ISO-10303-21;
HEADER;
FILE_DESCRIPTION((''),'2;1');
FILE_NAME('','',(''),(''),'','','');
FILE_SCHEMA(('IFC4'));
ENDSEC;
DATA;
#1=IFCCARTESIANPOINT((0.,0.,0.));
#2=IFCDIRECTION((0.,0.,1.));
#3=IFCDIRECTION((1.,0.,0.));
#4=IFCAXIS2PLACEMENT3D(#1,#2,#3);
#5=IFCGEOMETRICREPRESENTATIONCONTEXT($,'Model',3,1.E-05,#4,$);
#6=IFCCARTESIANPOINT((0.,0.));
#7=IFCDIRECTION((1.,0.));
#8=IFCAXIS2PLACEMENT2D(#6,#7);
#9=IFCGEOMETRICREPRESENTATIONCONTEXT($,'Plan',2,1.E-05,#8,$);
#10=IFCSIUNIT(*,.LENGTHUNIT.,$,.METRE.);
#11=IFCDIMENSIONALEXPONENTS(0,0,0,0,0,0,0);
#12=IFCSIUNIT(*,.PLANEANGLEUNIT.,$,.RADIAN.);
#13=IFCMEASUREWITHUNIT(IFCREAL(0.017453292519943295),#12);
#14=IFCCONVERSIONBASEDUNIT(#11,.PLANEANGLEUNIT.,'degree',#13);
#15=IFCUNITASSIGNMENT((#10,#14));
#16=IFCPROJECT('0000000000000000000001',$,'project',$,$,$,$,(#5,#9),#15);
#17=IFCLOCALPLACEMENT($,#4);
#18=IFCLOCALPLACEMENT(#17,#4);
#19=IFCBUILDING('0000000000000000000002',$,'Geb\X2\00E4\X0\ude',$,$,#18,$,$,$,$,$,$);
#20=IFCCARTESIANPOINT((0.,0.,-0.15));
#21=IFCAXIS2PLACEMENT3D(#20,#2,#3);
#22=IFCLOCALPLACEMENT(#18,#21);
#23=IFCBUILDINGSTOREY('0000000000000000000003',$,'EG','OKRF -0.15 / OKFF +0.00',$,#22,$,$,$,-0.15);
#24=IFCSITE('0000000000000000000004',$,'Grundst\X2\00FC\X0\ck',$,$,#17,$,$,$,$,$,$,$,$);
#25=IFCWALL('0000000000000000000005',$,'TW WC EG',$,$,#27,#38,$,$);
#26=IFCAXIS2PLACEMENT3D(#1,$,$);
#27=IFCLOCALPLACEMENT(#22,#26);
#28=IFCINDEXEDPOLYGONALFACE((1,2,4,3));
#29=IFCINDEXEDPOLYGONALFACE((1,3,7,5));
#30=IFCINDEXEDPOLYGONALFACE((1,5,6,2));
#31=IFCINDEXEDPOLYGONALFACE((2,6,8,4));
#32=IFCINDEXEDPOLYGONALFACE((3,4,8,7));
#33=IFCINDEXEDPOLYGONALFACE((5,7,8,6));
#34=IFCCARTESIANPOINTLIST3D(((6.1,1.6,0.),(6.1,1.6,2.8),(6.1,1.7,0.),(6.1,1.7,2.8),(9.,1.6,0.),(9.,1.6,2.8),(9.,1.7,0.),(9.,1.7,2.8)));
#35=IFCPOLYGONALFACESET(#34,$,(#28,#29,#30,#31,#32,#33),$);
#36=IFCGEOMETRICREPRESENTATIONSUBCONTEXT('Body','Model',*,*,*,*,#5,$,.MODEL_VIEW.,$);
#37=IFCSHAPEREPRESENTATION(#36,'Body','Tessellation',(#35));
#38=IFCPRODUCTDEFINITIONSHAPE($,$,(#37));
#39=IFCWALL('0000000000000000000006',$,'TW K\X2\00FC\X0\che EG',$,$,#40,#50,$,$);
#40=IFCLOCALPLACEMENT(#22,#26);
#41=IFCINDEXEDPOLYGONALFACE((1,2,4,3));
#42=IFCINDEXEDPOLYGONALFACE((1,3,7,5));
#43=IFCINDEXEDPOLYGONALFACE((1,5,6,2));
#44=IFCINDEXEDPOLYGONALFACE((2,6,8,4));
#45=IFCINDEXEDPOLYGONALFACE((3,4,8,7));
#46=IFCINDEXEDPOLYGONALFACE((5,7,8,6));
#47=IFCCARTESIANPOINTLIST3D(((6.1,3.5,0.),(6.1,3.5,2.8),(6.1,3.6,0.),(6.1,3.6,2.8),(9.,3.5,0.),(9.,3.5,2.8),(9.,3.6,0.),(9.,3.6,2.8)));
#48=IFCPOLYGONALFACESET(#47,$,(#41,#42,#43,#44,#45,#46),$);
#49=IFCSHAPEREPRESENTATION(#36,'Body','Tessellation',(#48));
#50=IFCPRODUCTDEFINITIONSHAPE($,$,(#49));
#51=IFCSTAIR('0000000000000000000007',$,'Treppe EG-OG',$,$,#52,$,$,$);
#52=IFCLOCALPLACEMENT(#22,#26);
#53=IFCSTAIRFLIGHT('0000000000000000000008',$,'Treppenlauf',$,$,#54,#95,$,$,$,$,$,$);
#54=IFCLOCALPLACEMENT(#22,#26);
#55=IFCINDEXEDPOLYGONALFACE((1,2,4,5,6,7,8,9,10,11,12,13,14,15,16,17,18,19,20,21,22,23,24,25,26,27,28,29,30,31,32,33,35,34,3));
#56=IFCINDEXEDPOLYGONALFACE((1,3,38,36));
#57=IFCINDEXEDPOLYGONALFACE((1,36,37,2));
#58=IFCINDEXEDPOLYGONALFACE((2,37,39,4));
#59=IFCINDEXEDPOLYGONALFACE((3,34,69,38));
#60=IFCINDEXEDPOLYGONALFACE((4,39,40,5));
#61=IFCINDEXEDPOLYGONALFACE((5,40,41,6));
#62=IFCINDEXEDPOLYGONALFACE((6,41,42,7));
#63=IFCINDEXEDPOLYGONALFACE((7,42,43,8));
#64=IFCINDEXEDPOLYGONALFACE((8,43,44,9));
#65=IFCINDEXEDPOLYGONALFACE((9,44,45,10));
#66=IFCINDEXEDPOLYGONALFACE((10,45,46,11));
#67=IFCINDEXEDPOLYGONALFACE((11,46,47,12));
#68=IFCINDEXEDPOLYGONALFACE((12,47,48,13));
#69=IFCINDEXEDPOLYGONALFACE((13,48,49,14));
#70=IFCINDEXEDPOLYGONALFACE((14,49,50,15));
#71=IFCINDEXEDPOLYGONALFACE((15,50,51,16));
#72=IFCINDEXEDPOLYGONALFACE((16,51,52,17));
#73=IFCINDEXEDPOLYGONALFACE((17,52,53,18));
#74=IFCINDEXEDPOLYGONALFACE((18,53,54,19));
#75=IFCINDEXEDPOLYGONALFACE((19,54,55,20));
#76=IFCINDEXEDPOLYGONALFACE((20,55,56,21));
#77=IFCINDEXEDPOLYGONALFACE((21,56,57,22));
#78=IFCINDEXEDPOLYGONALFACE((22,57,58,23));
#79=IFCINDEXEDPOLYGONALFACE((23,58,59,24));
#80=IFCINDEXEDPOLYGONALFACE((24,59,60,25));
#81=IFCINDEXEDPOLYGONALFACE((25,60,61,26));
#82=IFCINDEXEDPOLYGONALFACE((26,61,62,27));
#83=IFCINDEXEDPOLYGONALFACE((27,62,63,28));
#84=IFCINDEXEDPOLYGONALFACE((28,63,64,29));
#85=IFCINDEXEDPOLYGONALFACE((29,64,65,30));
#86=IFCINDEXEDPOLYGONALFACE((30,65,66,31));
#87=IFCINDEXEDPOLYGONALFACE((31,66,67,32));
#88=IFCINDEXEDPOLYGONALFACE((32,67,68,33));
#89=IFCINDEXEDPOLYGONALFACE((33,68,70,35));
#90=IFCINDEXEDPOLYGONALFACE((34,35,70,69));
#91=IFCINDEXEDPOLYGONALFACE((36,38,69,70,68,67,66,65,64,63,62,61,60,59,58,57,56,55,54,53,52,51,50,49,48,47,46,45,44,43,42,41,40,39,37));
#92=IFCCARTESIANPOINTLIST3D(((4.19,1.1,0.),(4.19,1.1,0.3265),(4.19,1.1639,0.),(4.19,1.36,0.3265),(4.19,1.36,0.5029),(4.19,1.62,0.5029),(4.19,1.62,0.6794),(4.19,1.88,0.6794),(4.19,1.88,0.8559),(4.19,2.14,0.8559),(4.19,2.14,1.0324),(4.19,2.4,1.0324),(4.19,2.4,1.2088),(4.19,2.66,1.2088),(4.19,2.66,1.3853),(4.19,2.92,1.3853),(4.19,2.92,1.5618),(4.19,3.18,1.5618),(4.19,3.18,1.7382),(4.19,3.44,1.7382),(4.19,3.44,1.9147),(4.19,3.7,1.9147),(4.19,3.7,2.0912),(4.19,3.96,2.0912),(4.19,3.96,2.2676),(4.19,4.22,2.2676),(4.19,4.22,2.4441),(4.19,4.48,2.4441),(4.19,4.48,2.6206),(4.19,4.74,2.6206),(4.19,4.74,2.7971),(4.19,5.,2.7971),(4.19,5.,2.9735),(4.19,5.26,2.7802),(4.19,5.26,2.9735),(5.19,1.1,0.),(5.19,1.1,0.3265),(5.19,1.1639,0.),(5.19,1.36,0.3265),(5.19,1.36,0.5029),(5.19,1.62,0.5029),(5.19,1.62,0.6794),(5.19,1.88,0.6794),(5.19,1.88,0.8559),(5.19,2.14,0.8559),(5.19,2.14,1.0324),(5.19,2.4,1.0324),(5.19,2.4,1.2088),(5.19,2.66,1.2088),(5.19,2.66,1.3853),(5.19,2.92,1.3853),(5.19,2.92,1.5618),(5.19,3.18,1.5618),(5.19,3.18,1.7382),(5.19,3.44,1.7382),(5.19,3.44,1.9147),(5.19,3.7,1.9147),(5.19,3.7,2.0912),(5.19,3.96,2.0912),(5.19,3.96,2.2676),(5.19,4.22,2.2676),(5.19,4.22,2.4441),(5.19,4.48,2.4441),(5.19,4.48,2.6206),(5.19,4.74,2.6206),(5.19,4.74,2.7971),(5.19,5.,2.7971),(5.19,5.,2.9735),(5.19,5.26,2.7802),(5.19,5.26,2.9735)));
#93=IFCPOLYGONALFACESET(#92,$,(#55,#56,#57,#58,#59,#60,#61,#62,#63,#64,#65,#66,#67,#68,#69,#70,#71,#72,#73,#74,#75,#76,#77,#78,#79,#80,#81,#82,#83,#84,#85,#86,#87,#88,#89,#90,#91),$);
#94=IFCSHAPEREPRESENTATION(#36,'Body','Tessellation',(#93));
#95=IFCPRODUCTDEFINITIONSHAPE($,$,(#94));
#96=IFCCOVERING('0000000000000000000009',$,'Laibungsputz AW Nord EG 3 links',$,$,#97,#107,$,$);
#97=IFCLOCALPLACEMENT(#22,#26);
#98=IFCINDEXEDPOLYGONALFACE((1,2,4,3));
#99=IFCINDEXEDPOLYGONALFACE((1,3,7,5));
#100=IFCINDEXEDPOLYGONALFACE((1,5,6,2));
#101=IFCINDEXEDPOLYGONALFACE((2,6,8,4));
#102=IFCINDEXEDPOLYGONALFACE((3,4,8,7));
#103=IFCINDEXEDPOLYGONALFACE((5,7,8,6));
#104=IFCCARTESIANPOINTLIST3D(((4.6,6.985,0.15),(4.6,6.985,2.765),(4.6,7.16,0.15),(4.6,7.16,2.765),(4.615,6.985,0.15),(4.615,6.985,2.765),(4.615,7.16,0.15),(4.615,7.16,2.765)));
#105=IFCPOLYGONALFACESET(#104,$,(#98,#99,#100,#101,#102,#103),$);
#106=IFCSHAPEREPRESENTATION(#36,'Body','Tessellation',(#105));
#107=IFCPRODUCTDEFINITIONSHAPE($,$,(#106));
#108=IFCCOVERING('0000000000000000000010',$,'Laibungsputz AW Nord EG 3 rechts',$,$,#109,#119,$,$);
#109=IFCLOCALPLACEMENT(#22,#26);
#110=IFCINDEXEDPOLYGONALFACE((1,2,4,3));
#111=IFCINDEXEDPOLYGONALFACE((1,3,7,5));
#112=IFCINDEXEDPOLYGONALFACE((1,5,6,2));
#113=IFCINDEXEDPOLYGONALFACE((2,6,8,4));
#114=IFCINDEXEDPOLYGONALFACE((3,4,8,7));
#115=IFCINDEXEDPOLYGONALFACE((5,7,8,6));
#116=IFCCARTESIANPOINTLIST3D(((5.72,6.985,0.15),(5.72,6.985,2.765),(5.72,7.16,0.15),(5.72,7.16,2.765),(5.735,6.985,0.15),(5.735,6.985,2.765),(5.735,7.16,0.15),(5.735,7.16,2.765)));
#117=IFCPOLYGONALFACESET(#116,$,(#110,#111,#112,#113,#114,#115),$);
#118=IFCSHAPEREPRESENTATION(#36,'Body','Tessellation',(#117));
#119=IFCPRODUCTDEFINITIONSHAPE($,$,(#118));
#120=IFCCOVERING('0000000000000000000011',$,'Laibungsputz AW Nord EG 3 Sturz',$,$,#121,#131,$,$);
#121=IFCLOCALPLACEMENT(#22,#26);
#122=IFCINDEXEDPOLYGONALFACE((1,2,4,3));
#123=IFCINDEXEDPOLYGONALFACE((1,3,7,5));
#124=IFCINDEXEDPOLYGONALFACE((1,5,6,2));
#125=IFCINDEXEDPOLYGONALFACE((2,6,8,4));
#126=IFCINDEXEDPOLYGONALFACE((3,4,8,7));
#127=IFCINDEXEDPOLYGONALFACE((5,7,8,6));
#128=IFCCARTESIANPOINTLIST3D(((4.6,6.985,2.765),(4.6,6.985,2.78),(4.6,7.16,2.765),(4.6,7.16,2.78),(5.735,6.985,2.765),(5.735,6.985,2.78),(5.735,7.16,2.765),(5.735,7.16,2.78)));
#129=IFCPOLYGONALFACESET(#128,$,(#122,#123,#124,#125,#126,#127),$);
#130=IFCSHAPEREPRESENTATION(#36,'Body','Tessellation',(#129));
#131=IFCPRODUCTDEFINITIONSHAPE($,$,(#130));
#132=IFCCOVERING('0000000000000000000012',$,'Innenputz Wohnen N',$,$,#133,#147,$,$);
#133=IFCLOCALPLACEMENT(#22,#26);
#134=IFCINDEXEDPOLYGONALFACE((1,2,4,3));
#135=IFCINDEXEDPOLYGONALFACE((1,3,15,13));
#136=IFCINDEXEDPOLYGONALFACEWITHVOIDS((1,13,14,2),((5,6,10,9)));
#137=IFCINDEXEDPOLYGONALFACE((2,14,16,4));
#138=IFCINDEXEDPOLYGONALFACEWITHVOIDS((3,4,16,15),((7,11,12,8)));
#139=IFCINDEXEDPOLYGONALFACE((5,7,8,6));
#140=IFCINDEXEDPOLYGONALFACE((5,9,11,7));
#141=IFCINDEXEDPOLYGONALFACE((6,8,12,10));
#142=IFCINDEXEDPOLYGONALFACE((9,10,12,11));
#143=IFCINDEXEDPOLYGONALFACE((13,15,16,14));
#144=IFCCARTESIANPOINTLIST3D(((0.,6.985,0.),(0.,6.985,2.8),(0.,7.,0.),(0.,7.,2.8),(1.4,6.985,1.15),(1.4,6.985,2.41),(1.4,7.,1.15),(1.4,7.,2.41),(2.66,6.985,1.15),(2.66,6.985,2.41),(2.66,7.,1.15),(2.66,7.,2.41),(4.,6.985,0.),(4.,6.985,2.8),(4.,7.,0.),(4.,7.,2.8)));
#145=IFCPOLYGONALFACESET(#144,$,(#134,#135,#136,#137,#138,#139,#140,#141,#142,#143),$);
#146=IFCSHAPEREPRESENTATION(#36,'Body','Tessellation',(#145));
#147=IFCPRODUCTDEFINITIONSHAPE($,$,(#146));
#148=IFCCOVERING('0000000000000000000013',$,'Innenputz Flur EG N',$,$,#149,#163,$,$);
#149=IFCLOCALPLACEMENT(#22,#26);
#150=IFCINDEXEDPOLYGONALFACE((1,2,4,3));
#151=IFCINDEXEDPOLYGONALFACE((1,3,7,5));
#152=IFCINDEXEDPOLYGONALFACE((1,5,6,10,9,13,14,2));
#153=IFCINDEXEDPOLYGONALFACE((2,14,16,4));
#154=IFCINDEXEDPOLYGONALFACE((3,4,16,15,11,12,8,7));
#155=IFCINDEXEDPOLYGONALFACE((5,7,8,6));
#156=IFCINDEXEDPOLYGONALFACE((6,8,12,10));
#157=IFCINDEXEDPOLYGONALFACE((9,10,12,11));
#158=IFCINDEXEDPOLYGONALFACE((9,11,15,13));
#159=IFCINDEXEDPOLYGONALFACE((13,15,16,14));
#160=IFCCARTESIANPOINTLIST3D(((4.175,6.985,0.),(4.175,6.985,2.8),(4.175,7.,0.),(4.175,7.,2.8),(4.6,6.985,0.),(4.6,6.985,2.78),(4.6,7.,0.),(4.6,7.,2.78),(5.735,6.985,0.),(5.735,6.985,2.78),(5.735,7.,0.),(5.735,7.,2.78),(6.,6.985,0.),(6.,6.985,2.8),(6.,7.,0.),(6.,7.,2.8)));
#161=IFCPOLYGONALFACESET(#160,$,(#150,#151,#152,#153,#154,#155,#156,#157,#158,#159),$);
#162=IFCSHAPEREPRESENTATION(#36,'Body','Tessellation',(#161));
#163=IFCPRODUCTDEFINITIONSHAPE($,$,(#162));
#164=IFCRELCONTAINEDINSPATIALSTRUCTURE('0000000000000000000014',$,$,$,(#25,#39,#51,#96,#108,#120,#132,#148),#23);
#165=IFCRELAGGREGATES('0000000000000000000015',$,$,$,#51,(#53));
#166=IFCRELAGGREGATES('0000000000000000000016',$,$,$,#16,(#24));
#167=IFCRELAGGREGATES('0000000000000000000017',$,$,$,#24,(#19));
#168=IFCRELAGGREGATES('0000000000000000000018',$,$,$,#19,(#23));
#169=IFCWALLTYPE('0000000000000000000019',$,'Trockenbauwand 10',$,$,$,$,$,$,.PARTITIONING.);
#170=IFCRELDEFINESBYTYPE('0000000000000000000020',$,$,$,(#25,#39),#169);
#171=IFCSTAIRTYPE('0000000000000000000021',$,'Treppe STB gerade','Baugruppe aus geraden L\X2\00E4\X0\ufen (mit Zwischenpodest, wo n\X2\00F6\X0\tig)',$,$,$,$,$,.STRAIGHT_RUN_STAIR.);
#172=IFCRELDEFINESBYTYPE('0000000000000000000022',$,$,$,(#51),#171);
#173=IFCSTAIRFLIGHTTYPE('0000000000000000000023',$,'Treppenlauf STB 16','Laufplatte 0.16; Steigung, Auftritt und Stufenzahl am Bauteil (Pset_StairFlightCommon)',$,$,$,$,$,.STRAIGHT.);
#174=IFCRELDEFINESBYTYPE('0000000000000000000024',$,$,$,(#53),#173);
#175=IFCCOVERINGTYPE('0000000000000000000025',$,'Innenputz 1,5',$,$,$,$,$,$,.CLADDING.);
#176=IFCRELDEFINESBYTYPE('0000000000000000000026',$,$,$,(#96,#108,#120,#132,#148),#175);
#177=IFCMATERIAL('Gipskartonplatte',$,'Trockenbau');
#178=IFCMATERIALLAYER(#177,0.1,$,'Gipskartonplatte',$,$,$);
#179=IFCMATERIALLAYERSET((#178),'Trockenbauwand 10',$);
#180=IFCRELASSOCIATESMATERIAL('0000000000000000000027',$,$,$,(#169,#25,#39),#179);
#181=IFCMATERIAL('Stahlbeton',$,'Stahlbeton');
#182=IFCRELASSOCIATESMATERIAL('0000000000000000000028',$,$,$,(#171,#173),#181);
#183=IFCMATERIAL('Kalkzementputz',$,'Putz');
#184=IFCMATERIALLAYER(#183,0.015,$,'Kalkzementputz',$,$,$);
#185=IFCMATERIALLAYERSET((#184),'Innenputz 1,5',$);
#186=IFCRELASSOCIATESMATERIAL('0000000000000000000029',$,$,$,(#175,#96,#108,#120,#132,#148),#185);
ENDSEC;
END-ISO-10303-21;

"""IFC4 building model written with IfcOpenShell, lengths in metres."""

from ifc_helpers import new_model, entity, si_unit, converted_unit, frame, origin, origin_with_axes, origin_2d_with_axis, place, context, subcontext, project, spatial, polyline, line, indexed_curve, outline, extrude, material, layer, layer_set, layer_usage, type_object, element, aggregate, save


model = new_model("IFC4")

# Units and contexts
model_context = context("Model", 3, precision=1e-05, world=origin_with_axes())
plan_context = context("Plan", 2, precision=1e-05, world=origin_2d_with_axis())
body_context_1 = subcontext(model_context, "Body", "Model", "MODEL_VIEW")
ifc_project = project(units=[si_unit("LENGTHUNIT", "METRE"), converted_unit("PLANEANGLEUNIT", "degree", entity("IfcReal", 0.017453292519943295), si_unit("PLANEANGLEUNIT", "RADIAN"), dimensions=[0, 0, 0, 0, 0, 0, 0])], contexts=[model_context, plan_context])

# Site, building, storey
site_placement = place(None, origin_with_axes())
site = spatial("IfcSite", under=ifc_project, at=site_placement, Name="Grundstück")
building_placement = place(site_placement, origin_with_axes())
building = spatial("IfcBuilding", under=site, at=building_placement, Name="Gebäude")
storey_placement = place(building_placement, frame((0.0, 0.0, -0.15), z_axis=(0.0, 0.0, 1.0), x_axis=(1.0, 0.0, 0.0)))
storey = spatial("IfcBuildingStorey", under=building, at=storey_placement, Name="EG", Description="OKRF -0.15 / OKFF +0.00", Elevation=-0.15)

# Shared definitions
ifc_material_1 = material(Name="Gipskartonplatte", Category="Trockenbau")
ifc_layer_1 = layer(ifc_material_1, 0.1, Name="Gipskartonplatte")
ifc_layer_set_1 = layer_set([ifc_layer_1], Name="Trockenbauwand 10")
wall_type_1 = type_object("IfcWallType", Name="Trockenbauwand 10", PredefinedType="PARTITIONING", material=ifc_layer_set_1)

# Walls
ifc_layer_usage_1 = layer_usage(ifc_layer_set_1, "AXIS2", "POSITIVE", 0.0)
wall_1_placement = place(storey_placement, frame((6.1, 1.6, 0.0), z_axis=(0.0, 0.0, 1.0), x_axis=(1.0, 0.0, 0.0)))
element("IfcWall", 1, at=wall_1_placement, inside=storey, type_object=wall_type_1, material=ifc_layer_usage_1, Name="TW WC EG", context=body_context_1, shape_type="SweptSolid", body=[
    extrude(outline(indexed_curve([(0.0, 0.0), (0.0, 0.1), (2.9, 0.1), (2.9, 0.0)], segments=[line(1, 2, 3, 4, 1)])), origin_with_axes(), (0.0, 0.0, 1.0), 2.8),
])
ifc_layer_usage_2 = layer_usage(ifc_layer_set_1, "AXIS2", "POSITIVE", 0.0)
wall_2_placement = place(storey_placement, frame((6.1, 3.5, 0.0), z_axis=(0.0, 0.0, 1.0), x_axis=(1.0, 0.0, 0.0)))
element("IfcWall", 2, at=wall_2_placement, inside=storey, type_object=wall_type_1, material=ifc_layer_usage_2, Name="TW Küche EG", context=body_context_1, shape_type="SweptSolid", body=[
    extrude(outline(indexed_curve([(0.0, 0.0), (0.0, 0.1), (2.9, 0.1), (2.9, 0.0)], segments=[line(1, 2, 3, 4, 1)])), origin_with_axes(), (0.0, 0.0, 1.0), 2.8),
])

# Stair, stair flight
ifc_material_2 = material(Name="Stahlbeton", Category="Stahlbeton")
stair_type = type_object("IfcStairType", Name="Treppe STB gerade", Description="Baugruppe aus geraden Läufen (mit Zwischenpodest, wo nötig)", PredefinedType="STRAIGHT_RUN_STAIR", material=ifc_material_2)
stair = element("IfcStair", 3, inside=storey, type_object=stair_type, Name="Treppe EG-OG")
stair_flight_type = type_object("IfcStairFlightType", Name="Treppenlauf STB 16", Description="Laufplatte 0.16; Steigung, Auftritt und Stufenzahl am Bauteil (Pset_StairFlightCommon)", PredefinedType="STRAIGHT", material=ifc_material_2)
stair_flight_placement = place(None, frame((4.19, 1.1, 0.0), z_axis=(1.0, 0.0, 0.0), x_axis=(0.0, 1.0, 0.0)))
stair_flight = element("IfcStairFlight", 4, at=stair_flight_placement, type_object=stair_flight_type, Name="Treppenlauf", context=body_context_1, shape_type="SweptSolid", body=[
    extrude(outline(indexed_curve([(0.0, -0.15), (0.0, 0.1765), (0.26, 0.1765), (0.26, 0.3529), (0.52, 0.3529), (0.52, 0.5294), (0.78, 0.5294), (0.78, 0.7059), (1.04, 0.7059), (1.04, 0.8824), (1.3, 0.8824), (1.3, 1.0588), (1.56, 1.0588), (1.56, 1.2353), (1.82, 1.2353), (1.82, 1.4118), (2.08, 1.4118), (2.08, 1.5882), (2.34, 1.5882), (2.34, 1.7647), (2.6, 1.7647), (2.6, 1.9412), (2.86, 1.9412), (2.86, 2.1176), (3.12, 2.1176), (3.12, 2.2941), (3.38, 2.2941), (3.38, 2.4706), (3.64, 2.4706), (3.64, 2.6471), (3.9, 2.6471), (3.9, 2.8235), (4.16, 2.8235), (4.16, 2.6302), (0.0639, -0.15), (0.0, -0.15)], self_intersect=False)), origin(), (0.0, 0.0, 1.0), 1.0),
])
aggregate(stair, [stair_flight])

# Coverings
ifc_material_3 = material(Name="Kalkzementputz", Category="Putz")
ifc_layer_2 = layer(ifc_material_3, 0.015, Name="Kalkzementputz")
ifc_layer_set_2 = layer_set([ifc_layer_2], Name="Innenputz 1,5")
ifc_layer_usage_3 = layer_usage(ifc_layer_set_2, "AXIS1", "POSITIVE", 4.6)
covering_type_1 = type_object("IfcCoveringType", Name="Innenputz 1,5", PredefinedType="CLADDING", material=ifc_layer_set_2)
covering_1_placement = place(storey_placement, frame((0.0, 7.0, 0.0), z_axis=(0.0, 0.0, 1.0), x_axis=(1.0, 0.0, 0.0)))
element("IfcCovering", 5, at=covering_1_placement, inside=storey, type_object=covering_type_1, material=ifc_layer_usage_3, Name="Laibungsputz AW Nord EG 3 links", context=body_context_1, shape_type="SweptSolid", body=[
    extrude(outline(polyline([(-0.015, 0.15), (0.16, 0.15), (0.16, 2.765), (-0.015, 2.765), (-0.015, 0.15)])), frame((4.6, 0.0, 0.0), z_axis=(1.0, 0.0, 0.0), x_axis=(0.0, 1.0, 0.0)), (0.0, 0.0, 1.0), 0.015),
])
ifc_layer_usage_4 = layer_usage(ifc_layer_set_2, "AXIS1", "POSITIVE", 5.72)
covering_2_placement = place(storey_placement, frame((0.0, 7.0, 0.0), z_axis=(0.0, 0.0, 1.0), x_axis=(1.0, 0.0, 0.0)))
element("IfcCovering", 6, at=covering_2_placement, inside=storey, type_object=covering_type_1, material=ifc_layer_usage_4, Name="Laibungsputz AW Nord EG 3 rechts", context=body_context_1, shape_type="SweptSolid", body=[
    extrude(outline(polyline([(-0.015, 0.15), (0.16, 0.15), (0.16, 2.765), (-0.015, 2.765), (-0.015, 0.15)])), frame((5.72, 0.0, 0.0), z_axis=(1.0, 0.0, 0.0), x_axis=(0.0, 1.0, 0.0)), (0.0, 0.0, 1.0), 0.015),
])
ifc_layer_usage_5 = layer_usage(ifc_layer_set_2, "AXIS3", "POSITIVE", 2.765)
covering_3_placement = place(storey_placement, frame((0.0, 7.0, 0.0), z_axis=(0.0, 0.0, 1.0), x_axis=(1.0, 0.0, 0.0)))
element("IfcCovering", 7, at=covering_3_placement, inside=storey, type_object=covering_type_1, material=ifc_layer_usage_5, Name="Laibungsputz AW Nord EG 3 Sturz", context=body_context_1, shape_type="SweptSolid", body=[
    extrude(outline(polyline([(-0.015, 2.765), (0.16, 2.765), (0.16, 2.78), (-0.015, 2.78), (-0.015, 2.765)])), frame((4.6, 0.0, 0.0), z_axis=(1.0, 0.0, 0.0), x_axis=(0.0, 1.0, 0.0)), (0.0, 0.0, 1.0), 1.135),
])

# Coverings, openings
ifc_layer_usage_6 = layer_usage(ifc_layer_set_2, "AXIS2", "POSITIVE", 0.0)
covering_4_placement = place(storey_placement, frame((4.0, 7.0, 0.0), z_axis=(0.0, 0.0, 1.0), x_axis=(-1.0, 0.0, 0.0)))
covering_4 = element("IfcCovering", 8, at=covering_4_placement, inside=storey, type_object=covering_type_1, material=ifc_layer_usage_6, Name="Innenputz Wohnen N", context=body_context_1, shape_type="SweptSolid", body=[
    extrude(outline(indexed_curve([(0.0, 0.0), (0.0, 0.015), (4.0, 0.015), (4.0, 0.0), (0.0, 0.0)], self_intersect=False)), origin_with_axes(), (0.0, 0.0, 1.0), 2.8),
])
opening_1_placement = place(covering_4_placement, frame((1.34, -0.05, 1.15), z_axis=(0.0, 0.0, 1.0), x_axis=(1.0, 0.0, 0.0)))
element("IfcOpeningElement", 9, at=opening_1_placement, cuts=covering_4, context=body_context_1, shape_type="SweptSolid", body=[
    extrude(outline(indexed_curve([(0.0, 0.0), (0.0, 0.115), (1.26, 0.115), (1.26, 0.0), (0.0, 0.0)], self_intersect=False)), origin_with_axes(), (0.0, 0.0, 1.0), 1.26),
])
ifc_layer_usage_7 = layer_usage(ifc_layer_set_2, "AXIS2", "POSITIVE", 0.0)
covering_5_placement = place(storey_placement, frame((6.0, 7.0, 0.0), z_axis=(0.0, 0.0, 1.0), x_axis=(-1.0, 0.0, 0.0)))
covering_5 = element("IfcCovering", 10, at=covering_5_placement, inside=storey, type_object=covering_type_1, material=ifc_layer_usage_7, Name="Innenputz Flur EG N", context=body_context_1, shape_type="SweptSolid", body=[
    extrude(outline(indexed_curve([(0.0, 0.0), (0.0, 0.015), (1.825, 0.015), (1.825, 0.0), (0.0, 0.0)], self_intersect=False)), origin_with_axes(), (0.0, 0.0, 1.0), 2.8),
])
opening_2_placement = place(covering_5_placement, frame((0.265, -0.05, 0.0), z_axis=(0.0, 0.0, 1.0), x_axis=(1.0, 0.0, 0.0)))
element("IfcOpeningElement", 11, at=opening_2_placement, cuts=covering_5, context=body_context_1, shape_type="SweptSolid", body=[
    extrude(outline(indexed_curve([(0.0, 0.0), (0.0, 0.115), (1.135, 0.115), (1.135, 0.0), (0.0, 0.0)], self_intersect=False)), origin_with_axes(), (0.0, 0.0, 1.0), 2.78),
])

save(model, "model.ifc")
